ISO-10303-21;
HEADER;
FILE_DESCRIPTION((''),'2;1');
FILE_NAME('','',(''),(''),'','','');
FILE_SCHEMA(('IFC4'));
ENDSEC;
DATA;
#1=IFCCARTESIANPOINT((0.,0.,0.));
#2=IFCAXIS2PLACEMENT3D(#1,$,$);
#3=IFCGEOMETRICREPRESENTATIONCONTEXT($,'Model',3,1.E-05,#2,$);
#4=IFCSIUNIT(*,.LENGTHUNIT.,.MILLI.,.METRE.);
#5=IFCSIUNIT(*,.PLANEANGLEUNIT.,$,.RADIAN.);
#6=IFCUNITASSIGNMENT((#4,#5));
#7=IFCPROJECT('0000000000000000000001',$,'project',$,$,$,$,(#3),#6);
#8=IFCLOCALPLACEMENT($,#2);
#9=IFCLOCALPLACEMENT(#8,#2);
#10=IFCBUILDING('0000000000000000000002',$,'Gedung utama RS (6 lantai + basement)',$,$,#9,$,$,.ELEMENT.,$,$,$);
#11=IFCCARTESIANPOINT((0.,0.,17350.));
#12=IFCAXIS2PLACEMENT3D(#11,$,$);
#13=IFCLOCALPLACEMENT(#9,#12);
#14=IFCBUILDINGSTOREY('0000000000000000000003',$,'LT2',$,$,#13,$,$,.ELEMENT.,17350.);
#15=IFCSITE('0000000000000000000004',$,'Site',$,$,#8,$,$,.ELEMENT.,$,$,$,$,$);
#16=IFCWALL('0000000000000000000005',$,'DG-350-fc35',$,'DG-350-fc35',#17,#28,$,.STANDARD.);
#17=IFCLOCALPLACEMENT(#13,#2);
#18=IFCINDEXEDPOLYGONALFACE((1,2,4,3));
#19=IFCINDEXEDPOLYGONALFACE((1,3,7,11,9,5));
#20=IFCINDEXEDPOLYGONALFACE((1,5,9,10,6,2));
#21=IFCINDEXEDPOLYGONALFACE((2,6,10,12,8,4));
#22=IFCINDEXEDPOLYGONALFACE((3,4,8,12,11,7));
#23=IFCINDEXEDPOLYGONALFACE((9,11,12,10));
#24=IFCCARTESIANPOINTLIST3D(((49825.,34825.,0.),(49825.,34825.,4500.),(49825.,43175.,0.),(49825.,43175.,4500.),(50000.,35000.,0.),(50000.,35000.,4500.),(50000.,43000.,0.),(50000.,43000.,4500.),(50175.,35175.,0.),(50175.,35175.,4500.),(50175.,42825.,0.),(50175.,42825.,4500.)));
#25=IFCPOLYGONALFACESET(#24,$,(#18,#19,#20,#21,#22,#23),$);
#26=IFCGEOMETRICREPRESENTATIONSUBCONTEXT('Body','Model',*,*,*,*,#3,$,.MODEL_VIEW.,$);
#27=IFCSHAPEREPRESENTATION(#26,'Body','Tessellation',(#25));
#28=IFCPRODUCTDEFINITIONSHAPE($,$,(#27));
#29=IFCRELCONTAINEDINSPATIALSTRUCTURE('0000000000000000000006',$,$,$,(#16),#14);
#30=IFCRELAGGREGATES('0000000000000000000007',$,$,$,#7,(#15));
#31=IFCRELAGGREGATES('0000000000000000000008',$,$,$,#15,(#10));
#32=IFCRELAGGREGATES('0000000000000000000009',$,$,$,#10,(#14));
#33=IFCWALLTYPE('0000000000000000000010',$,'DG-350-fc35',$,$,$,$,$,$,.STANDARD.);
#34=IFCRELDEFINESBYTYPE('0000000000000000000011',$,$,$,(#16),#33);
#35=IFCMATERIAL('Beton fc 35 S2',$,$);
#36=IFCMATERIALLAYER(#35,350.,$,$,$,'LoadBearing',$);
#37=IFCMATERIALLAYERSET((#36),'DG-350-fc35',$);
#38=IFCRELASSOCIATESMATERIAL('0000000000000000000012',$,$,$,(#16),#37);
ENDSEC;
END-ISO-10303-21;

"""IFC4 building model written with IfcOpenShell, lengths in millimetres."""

from ifc_helpers import new_model, si_unit, frame, origin, place, context, subcontext, project, spatial, polyline, outline, extrude, material, layer, layer_set, layer_usage, type_object, element, save


model = new_model("IFC4")

# Units and contexts
model_context = context("Model", 3, precision=1e-05, world=origin())
body_context = subcontext(model_context, "Body", "Model", "MODEL_VIEW")
ifc_project = project(units=[si_unit("LENGTHUNIT", "METRE", prefix="MILLI"), si_unit("PLANEANGLEUNIT", "RADIAN")], contexts=[model_context])

# Site, building, storey
site_placement = place(None, origin())
site = spatial("IfcSite", under=ifc_project, at=site_placement, Name="Site", CompositionType="ELEMENT")
building_placement = place(site_placement, origin())
building = spatial("IfcBuilding", under=site, at=building_placement, Name="Gedung utama RS (6 lantai + basement)", CompositionType="ELEMENT")
storey_placement = place(building_placement, frame((0.0, 0.0, 17350.0)))
storey = spatial("IfcBuildingStorey", under=building, at=storey_placement, Name="LT2", CompositionType="ELEMENT", Elevation=17350.0)

# Shared definitions
ifc_material_1 = material(Name="Beton fc 35 S2")
ifc_layer = layer(ifc_material_1, 350.0, Category="LoadBearing")
ifc_layer_set = layer_set([ifc_layer], Name="DG-350-fc35")
ifc_layer_usage = layer_usage(ifc_layer_set, "AXIS2", "NEGATIVE", 175.0)
wall_type = type_object("IfcWallType", Name="DG-350-fc35", PredefinedType="STANDARD")

# Wall
for number, where, z_axis, x_axis, name in (
    (1, (50000.0, 43000.0, 0.0), (0.0, 0.0, 1.0), (0.0, -1.0, 0.0), "DG-350-fc35"),
):
    element("IfcWall", number, at=place(storey_placement, frame(where, z_axis=z_axis, x_axis=x_axis)), inside=storey, type_object=wall_type, material=ifc_layer_usage, Name=name, ObjectType="DG-350-fc35", PredefinedType="STANDARD", context=body_context, shape_type="SweptSolid", body=[
        extrude(outline(polyline([(-175.0, -175.0), (0.0, 0.0), (175.0, 175.0), (7825.0, 175.0), (8000.0, 0.0), (8175.0, -175.0), (-175.0, -175.0)])), origin(), (0.0, 0.0, 1.0), 4500.0),
    ])

save(model, "model.ifc")
